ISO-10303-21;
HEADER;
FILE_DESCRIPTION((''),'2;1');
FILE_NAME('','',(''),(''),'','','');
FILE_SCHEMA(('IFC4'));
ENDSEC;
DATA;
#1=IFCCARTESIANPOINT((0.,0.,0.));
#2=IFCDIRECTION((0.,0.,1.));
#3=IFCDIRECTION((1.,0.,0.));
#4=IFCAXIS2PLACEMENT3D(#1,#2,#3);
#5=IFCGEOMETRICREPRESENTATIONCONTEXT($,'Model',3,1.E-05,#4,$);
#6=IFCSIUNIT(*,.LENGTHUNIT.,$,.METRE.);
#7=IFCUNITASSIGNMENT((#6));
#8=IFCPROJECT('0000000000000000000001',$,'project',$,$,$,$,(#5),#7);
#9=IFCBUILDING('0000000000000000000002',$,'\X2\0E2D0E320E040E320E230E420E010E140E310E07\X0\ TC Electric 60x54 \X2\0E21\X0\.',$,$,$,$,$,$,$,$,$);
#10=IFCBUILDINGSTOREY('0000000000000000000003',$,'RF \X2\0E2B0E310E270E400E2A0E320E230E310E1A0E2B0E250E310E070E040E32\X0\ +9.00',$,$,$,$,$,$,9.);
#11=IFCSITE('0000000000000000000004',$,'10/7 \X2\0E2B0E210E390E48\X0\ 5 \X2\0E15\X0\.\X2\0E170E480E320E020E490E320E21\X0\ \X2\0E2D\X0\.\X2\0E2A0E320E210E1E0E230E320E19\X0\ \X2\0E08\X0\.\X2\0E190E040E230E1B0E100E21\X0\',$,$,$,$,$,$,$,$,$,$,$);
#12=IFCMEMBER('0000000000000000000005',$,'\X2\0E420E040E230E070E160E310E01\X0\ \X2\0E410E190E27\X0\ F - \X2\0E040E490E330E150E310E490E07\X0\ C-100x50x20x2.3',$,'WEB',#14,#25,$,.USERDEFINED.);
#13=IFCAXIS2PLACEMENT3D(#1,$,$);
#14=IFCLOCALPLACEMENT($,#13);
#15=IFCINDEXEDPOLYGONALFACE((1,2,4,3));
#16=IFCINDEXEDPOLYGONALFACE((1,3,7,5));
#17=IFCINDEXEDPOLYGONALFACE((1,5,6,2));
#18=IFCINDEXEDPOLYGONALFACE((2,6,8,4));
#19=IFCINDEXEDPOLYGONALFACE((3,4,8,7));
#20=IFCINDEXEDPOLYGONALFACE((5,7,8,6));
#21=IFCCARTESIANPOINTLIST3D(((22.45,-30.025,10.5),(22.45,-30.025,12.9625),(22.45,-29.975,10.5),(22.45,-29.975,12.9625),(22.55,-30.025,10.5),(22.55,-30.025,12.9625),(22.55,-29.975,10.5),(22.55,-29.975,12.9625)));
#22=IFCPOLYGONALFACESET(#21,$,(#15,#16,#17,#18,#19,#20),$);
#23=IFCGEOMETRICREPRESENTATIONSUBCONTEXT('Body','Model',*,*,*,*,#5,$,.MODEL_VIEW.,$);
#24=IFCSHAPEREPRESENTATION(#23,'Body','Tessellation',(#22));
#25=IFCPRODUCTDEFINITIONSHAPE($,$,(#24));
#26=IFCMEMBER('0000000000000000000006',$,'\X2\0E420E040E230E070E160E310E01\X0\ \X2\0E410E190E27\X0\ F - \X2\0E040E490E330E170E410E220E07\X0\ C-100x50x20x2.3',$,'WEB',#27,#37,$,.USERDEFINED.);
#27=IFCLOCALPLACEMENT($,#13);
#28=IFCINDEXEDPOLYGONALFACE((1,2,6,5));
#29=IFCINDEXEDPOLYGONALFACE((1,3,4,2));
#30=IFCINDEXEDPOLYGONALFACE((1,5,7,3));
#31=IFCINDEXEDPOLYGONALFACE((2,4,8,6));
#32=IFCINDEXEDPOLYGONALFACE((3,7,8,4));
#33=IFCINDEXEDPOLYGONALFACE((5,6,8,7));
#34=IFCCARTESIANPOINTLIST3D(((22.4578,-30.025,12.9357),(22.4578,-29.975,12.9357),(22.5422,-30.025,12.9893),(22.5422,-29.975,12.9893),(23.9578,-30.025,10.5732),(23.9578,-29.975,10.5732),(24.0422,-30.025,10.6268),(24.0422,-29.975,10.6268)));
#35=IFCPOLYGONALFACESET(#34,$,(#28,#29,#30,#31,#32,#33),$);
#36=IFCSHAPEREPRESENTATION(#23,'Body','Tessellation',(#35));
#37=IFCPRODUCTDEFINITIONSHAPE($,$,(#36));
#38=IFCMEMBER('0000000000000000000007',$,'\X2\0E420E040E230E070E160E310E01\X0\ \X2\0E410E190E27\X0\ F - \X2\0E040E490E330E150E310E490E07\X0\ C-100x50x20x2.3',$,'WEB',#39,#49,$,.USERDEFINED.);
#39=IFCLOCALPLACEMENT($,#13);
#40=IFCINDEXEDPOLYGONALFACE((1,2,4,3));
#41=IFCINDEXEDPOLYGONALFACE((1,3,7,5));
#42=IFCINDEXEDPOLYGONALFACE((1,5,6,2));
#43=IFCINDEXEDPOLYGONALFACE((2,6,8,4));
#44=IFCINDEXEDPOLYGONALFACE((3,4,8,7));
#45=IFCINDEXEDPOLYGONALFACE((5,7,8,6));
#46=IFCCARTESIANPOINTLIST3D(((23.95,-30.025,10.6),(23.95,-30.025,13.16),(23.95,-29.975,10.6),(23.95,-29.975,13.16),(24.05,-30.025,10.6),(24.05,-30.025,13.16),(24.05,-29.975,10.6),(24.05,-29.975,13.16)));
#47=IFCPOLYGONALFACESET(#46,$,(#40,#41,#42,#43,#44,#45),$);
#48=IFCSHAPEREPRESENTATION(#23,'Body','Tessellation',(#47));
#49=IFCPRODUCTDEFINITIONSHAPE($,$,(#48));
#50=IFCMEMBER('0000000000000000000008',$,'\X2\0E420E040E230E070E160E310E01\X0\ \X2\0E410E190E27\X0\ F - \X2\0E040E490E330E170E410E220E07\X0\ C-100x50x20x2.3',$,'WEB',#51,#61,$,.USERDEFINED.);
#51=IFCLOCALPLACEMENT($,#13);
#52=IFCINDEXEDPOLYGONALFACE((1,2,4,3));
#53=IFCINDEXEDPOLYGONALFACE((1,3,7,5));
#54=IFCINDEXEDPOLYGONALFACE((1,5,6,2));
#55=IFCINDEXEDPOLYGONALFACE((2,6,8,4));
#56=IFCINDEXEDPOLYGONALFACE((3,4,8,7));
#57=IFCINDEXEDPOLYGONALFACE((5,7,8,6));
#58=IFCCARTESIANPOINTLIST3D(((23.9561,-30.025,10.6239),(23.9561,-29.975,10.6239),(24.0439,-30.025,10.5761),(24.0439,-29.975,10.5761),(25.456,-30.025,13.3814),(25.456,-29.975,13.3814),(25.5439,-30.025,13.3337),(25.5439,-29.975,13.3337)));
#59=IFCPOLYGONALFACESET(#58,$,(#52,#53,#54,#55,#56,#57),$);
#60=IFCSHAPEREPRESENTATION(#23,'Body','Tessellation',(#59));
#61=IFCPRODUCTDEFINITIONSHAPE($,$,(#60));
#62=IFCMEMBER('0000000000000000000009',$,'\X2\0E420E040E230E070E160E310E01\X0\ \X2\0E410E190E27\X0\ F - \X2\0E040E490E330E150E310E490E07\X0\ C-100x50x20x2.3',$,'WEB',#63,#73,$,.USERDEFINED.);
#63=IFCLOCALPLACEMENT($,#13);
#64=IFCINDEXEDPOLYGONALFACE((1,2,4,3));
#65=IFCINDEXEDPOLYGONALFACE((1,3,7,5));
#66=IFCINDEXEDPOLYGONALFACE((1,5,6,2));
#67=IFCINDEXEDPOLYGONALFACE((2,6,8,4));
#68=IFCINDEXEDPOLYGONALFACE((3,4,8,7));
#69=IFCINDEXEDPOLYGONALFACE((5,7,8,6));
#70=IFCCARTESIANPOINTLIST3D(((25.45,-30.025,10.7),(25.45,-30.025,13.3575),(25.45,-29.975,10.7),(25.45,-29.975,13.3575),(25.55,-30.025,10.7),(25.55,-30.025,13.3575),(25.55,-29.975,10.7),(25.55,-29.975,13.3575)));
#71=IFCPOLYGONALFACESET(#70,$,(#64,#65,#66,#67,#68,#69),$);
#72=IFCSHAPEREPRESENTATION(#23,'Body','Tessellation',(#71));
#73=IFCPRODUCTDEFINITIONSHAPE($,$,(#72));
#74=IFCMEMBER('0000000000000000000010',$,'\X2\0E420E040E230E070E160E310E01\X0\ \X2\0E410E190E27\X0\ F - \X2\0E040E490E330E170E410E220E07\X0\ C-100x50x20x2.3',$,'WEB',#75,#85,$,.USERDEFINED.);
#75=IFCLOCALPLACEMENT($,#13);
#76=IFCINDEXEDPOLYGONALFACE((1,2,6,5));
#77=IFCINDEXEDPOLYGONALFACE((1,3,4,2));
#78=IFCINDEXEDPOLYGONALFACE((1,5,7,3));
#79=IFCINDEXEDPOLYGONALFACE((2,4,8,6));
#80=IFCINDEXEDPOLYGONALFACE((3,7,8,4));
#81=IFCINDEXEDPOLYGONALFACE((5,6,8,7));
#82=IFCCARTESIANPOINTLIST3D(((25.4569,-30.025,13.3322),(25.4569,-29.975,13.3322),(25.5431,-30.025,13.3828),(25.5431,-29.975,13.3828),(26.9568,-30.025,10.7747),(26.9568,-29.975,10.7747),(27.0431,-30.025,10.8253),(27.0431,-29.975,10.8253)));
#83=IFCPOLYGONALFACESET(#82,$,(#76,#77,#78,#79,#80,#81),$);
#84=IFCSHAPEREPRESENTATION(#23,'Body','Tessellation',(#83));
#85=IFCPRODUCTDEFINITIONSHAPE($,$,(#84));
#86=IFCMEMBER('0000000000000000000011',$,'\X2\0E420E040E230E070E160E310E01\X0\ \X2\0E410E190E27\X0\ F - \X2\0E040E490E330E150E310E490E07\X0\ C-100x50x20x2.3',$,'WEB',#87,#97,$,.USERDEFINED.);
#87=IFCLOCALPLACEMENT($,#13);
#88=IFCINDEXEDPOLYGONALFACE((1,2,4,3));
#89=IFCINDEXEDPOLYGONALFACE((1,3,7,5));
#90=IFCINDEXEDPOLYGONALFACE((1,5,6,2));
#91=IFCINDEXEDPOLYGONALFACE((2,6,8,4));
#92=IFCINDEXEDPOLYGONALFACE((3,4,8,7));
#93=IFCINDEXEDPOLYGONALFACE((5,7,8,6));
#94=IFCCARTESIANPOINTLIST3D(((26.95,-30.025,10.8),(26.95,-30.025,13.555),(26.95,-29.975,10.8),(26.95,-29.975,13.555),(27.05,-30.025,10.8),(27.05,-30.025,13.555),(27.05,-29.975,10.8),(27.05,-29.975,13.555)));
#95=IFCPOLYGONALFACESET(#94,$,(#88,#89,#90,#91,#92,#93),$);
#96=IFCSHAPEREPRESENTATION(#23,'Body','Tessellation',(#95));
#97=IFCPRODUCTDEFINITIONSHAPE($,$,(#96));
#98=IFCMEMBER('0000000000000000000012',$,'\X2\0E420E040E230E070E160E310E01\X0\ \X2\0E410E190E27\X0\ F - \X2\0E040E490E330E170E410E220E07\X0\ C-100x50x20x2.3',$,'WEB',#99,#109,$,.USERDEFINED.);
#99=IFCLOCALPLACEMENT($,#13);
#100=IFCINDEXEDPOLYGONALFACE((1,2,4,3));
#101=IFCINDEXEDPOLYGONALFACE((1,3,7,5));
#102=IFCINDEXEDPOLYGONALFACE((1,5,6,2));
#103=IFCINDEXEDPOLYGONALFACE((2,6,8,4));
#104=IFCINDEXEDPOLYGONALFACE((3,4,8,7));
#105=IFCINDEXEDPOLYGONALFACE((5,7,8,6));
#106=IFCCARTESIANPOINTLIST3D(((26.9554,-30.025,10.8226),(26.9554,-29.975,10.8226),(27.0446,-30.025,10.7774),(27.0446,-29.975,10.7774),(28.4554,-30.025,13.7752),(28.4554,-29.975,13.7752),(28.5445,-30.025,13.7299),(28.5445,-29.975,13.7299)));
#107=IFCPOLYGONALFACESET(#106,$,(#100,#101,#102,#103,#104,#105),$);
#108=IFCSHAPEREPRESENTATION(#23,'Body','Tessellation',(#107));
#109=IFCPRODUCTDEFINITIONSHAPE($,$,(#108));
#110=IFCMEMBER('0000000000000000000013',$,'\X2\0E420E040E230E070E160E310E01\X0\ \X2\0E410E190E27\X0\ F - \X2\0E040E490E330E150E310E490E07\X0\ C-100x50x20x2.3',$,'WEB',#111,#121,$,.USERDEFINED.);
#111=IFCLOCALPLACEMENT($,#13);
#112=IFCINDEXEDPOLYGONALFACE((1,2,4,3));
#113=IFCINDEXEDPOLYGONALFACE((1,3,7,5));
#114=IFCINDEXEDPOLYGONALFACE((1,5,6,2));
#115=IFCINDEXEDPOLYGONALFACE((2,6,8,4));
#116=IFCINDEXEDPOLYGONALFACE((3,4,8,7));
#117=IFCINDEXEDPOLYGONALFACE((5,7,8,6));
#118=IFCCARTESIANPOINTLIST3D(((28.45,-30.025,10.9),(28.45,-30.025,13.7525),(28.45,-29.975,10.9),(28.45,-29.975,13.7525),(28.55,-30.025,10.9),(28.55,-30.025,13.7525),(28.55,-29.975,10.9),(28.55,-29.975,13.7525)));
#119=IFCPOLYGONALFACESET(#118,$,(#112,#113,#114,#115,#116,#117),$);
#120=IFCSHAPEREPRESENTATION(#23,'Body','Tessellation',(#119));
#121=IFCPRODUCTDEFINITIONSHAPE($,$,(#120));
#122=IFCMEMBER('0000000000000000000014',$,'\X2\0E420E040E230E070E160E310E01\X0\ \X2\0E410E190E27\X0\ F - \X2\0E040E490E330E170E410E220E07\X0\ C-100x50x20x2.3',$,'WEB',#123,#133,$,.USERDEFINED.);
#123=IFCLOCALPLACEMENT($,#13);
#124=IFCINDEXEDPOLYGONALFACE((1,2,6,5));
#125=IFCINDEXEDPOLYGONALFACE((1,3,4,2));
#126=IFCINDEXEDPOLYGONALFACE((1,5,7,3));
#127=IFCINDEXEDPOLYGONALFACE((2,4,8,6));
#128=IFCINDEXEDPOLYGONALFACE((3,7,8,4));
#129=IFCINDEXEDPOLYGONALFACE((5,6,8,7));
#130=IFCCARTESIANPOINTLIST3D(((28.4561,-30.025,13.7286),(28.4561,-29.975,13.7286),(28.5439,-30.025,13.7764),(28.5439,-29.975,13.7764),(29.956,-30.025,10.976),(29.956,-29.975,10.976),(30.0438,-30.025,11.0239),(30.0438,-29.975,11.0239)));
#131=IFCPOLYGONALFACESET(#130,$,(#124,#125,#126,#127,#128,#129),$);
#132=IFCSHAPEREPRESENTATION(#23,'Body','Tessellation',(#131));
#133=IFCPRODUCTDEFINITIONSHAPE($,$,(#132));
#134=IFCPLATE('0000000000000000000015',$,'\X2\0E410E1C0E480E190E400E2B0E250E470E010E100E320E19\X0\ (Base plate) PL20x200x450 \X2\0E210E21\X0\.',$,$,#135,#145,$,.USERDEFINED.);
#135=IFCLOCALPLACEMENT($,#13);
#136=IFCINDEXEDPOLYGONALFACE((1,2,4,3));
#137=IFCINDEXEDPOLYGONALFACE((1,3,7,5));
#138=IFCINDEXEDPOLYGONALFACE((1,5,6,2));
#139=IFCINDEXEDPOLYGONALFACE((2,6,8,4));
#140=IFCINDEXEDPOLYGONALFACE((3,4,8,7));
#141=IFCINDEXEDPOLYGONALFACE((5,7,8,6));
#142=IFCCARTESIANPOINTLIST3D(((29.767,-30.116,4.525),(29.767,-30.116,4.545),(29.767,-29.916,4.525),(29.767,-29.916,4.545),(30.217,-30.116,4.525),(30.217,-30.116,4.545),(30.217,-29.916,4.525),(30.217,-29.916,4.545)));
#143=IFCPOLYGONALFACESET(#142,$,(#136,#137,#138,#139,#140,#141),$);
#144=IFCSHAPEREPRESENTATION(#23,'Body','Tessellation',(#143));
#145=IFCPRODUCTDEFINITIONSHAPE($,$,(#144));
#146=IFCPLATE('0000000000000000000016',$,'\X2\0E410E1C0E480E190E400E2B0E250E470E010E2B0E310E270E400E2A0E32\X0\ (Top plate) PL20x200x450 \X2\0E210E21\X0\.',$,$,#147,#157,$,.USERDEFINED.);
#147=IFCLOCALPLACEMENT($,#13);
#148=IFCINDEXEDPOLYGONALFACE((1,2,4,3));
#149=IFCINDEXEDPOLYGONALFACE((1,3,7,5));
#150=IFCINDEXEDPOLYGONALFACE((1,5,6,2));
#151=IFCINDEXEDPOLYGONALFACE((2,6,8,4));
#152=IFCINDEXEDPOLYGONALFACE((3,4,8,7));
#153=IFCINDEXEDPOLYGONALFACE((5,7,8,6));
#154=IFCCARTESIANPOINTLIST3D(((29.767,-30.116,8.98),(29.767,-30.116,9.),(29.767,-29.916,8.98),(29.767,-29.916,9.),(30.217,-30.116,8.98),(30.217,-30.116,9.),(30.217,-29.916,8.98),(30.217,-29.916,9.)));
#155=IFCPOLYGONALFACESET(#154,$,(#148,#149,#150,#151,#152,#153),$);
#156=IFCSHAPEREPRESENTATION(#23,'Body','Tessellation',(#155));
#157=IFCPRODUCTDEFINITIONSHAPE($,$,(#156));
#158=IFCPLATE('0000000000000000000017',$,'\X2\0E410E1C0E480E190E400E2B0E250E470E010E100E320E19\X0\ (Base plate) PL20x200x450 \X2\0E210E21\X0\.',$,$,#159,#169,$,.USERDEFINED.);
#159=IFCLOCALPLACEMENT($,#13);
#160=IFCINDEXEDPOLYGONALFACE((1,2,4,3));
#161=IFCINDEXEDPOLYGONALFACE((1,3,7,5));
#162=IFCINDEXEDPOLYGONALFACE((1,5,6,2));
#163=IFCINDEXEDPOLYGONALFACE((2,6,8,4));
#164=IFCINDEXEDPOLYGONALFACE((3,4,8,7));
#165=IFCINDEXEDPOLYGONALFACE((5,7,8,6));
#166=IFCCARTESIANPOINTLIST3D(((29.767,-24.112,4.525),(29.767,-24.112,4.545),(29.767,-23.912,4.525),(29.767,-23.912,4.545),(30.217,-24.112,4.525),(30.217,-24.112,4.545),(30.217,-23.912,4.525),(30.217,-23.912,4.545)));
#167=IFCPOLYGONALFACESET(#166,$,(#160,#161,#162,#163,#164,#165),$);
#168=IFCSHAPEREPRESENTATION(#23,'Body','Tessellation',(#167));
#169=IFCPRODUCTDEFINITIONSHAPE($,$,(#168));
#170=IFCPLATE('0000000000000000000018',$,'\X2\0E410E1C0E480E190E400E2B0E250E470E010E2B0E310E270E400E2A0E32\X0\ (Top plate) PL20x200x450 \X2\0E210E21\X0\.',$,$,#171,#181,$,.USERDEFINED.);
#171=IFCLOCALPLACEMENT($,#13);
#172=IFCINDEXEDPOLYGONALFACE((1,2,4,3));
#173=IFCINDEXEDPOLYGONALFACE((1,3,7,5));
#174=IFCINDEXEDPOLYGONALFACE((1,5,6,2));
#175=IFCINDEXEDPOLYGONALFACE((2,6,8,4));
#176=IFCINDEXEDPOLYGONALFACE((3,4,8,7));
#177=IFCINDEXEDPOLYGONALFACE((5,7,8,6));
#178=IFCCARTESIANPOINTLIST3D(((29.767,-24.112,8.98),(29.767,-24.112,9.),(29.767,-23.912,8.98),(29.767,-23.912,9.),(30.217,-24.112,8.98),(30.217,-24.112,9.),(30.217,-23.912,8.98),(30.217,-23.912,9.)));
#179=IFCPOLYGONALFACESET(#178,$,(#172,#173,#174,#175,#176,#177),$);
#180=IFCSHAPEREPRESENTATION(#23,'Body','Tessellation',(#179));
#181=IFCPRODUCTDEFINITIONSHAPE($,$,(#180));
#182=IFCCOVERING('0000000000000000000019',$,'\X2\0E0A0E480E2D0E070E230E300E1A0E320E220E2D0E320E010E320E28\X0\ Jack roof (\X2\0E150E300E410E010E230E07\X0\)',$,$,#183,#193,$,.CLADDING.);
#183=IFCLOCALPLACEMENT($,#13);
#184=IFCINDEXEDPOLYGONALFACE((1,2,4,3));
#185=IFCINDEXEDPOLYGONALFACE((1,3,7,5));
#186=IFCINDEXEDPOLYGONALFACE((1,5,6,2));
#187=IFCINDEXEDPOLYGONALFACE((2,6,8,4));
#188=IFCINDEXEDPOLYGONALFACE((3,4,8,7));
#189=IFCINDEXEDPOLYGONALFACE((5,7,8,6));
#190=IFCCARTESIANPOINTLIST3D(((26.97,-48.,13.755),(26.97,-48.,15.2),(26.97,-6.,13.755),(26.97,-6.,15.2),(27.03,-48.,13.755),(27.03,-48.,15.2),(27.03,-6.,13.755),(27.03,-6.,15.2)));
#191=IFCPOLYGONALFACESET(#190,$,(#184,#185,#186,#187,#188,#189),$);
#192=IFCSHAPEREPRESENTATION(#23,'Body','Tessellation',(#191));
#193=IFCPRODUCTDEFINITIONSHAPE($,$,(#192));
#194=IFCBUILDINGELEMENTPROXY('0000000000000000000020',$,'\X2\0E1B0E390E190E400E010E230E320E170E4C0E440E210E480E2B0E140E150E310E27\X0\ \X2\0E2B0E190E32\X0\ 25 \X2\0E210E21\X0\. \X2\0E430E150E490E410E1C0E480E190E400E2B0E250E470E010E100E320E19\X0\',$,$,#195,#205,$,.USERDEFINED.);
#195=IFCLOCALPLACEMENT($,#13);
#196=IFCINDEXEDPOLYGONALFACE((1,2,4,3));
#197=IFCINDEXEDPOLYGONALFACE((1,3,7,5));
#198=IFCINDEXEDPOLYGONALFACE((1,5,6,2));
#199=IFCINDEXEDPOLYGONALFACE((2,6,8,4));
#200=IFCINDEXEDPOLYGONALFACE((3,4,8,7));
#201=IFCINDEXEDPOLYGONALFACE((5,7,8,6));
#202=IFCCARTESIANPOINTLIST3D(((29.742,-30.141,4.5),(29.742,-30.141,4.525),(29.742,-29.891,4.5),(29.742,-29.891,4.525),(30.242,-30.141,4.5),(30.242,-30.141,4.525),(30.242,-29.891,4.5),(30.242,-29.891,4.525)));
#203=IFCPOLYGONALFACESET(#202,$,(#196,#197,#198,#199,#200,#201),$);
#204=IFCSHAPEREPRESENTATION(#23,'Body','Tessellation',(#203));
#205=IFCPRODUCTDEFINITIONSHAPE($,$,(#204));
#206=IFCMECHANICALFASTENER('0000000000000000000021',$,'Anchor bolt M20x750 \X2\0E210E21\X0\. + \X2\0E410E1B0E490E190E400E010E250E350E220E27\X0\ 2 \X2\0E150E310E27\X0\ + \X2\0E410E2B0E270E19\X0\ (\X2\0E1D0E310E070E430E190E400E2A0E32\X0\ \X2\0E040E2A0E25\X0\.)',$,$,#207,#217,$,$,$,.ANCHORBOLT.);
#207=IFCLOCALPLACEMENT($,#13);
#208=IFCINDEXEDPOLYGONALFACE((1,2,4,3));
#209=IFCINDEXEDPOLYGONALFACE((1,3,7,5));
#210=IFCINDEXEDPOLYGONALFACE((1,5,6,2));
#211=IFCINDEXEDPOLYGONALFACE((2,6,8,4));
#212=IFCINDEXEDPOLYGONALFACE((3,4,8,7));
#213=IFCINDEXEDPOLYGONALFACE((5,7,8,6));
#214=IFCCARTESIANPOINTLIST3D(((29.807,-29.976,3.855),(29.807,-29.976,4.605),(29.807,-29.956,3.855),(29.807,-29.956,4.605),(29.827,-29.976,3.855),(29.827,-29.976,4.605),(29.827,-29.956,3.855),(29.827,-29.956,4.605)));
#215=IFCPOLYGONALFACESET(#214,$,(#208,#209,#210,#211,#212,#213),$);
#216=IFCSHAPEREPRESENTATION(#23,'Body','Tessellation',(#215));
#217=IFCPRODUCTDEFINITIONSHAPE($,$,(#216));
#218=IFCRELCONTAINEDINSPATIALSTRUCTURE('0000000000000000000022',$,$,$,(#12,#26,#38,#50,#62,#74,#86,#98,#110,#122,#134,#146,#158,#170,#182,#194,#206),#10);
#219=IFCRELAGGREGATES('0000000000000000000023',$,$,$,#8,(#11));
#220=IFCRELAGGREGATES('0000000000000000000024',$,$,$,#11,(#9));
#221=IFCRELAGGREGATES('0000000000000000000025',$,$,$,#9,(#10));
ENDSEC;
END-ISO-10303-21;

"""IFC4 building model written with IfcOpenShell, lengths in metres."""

from ifc_helpers import new_model, si_unit, frame, origin, origin_with_axes, origin_2d, place, context, subcontext, project, spatial, rectangle, extrude, element, save


model = new_model("IFC4")

# Units and contexts
model_context = context("Model", 3, precision=1e-05, world=origin_with_axes())
body_context = subcontext(model_context, "Body", "Model", "MODEL_VIEW")
ifc_project = project(units=[si_unit("LENGTHUNIT", "METRE")], contexts=[model_context])

# Site, building, storey
site = spatial("IfcSite", under=ifc_project, Name="10/7 หมู่ 5 ต.ท่าข้าม อ.สามพราน จ.นครปฐม")
building = spatial("IfcBuilding", under=site, Name="อาคารโกดัง TC Electric 60x54 ม.")
storey = spatial("IfcBuildingStorey", under=building, Name="RF หัวเสารับหลังคา +9.00", Elevation=9.0)

# Members
member_1_placement = place(None, frame((22.5, -30.0, 10.5), z_axis=(0.0, 0.0, 1.0), x_axis=(0.0, 1.0, 0.0)))
element("IfcMember", 1, at=member_1_placement, inside=storey, Name="โครงถัก แนว F - ค้ำตั้ง C-100x50x20x2.3", ObjectType="WEB", PredefinedType="USERDEFINED", context=body_context, shape_type="SweptSolid", body=[
    extrude(rectangle(XDim=0.05, YDim=0.1, at=origin_2d()), origin(), (0.0, 0.0, 1.0), 2.4625),
])
member_2_placement = place(None, frame((22.5, -30.0, 12.9625), z_axis=(0.536, 0.0, -0.8442), x_axis=(0.0, -1.0, 0.0)))
element("IfcMember", 2, at=member_2_placement, inside=storey, Name="โครงถัก แนว F - ค้ำทแยง C-100x50x20x2.3", ObjectType="WEB", PredefinedType="USERDEFINED", context=body_context, shape_type="SweptSolid", body=[
    extrude(rectangle(XDim=0.05, YDim=0.1, at=origin_2d()), origin(), (0.0, 0.0, 1.0), 2.7985),
])
member_3_placement = place(None, frame((24.0, -30.0, 10.6), z_axis=(0.0, 0.0, 1.0), x_axis=(0.0, 1.0, 0.0)))
element("IfcMember", 3, at=member_3_placement, inside=storey, Name="โครงถัก แนว F - ค้ำตั้ง C-100x50x20x2.3", ObjectType="WEB", PredefinedType="USERDEFINED", context=body_context, shape_type="SweptSolid", body=[
    extrude(rectangle(XDim=0.05, YDim=0.1, at=origin_2d()), origin(), (0.0, 0.0, 1.0), 2.56),
])
member_4_placement = place(None, frame((24.0, -30.0, 10.6), z_axis=(0.4778, 0.0, 0.8784), x_axis=(0.0, -1.0, 0.0)))
element("IfcMember", 4, at=member_4_placement, inside=storey, Name="โครงถัก แนว F - ค้ำทแยง C-100x50x20x2.3", ObjectType="WEB", PredefinedType="USERDEFINED", context=body_context, shape_type="SweptSolid", body=[
    extrude(rectangle(XDim=0.05, YDim=0.1, at=origin_2d()), origin(), (0.0, 0.0, 1.0), 3.1391),
])
member_5_placement = place(None, frame((25.5, -30.0, 10.7), z_axis=(0.0, 0.0, 1.0), x_axis=(0.0, 1.0, 0.0)))
element("IfcMember", 5, at=member_5_placement, inside=storey, Name="โครงถัก แนว F - ค้ำตั้ง C-100x50x20x2.3", ObjectType="WEB", PredefinedType="USERDEFINED", context=body_context, shape_type="SweptSolid", body=[
    extrude(rectangle(XDim=0.05, YDim=0.1, at=origin_2d()), origin(), (0.0, 0.0, 1.0), 2.6575),
])
member_6_placement = place(None, frame((25.5, -30.0, 13.3575), z_axis=(0.5059, 0.0, -0.8626), x_axis=(0.0, -1.0, 0.0)))
element("IfcMember", 6, at=member_6_placement, inside=storey, Name="โครงถัก แนว F - ค้ำทแยง C-100x50x20x2.3", ObjectType="WEB", PredefinedType="USERDEFINED", context=body_context, shape_type="SweptSolid", body=[
    extrude(rectangle(XDim=0.05, YDim=0.1, at=origin_2d()), origin(), (0.0, 0.0, 1.0), 2.9649),
])
member_7_placement = place(None, frame((27.0, -30.0, 10.8), z_axis=(0.0, 0.0, 1.0), x_axis=(0.0, 1.0, 0.0)))
element("IfcMember", 7, at=member_7_placement, inside=storey, Name="โครงถัก แนว F - ค้ำตั้ง C-100x50x20x2.3", ObjectType="WEB", PredefinedType="USERDEFINED", context=body_context, shape_type="SweptSolid", body=[
    extrude(rectangle(XDim=0.05, YDim=0.1, at=origin_2d()), origin(), (0.0, 0.0, 1.0), 2.755),
])
member_8_placement = place(None, frame((27.0, -30.0, 10.8), z_axis=(0.4529, 0.0, 0.8915), x_axis=(0.0, -1.0, 0.0)))
element("IfcMember", 8, at=member_8_placement, inside=storey, Name="โครงถัก แนว F - ค้ำทแยง C-100x50x20x2.3", ObjectType="WEB", PredefinedType="USERDEFINED", context=body_context, shape_type="SweptSolid", body=[
    extrude(rectangle(XDim=0.05, YDim=0.1, at=origin_2d()), origin(), (0.0, 0.0, 1.0), 3.3117),
])
member_9_placement = place(None, frame((28.5, -30.0, 10.9), z_axis=(0.0, 0.0, 1.0), x_axis=(0.0, 1.0, 0.0)))
element("IfcMember", 9, at=member_9_placement, inside=storey, Name="โครงถัก แนว F - ค้ำตั้ง C-100x50x20x2.3", ObjectType="WEB", PredefinedType="USERDEFINED", context=body_context, shape_type="SweptSolid", body=[
    extrude(rectangle(XDim=0.05, YDim=0.1, at=origin_2d()), origin(), (0.0, 0.0, 1.0), 2.8525),
])
member_10_placement = place(None, frame((28.5, -30.0, 13.7525), z_axis=(0.4785, 0.0, -0.8781), x_axis=(0.0, -1.0, 0.0)))
element("IfcMember", 10, at=member_10_placement, inside=storey, Name="โครงถัก แนว F - ค้ำทแยง C-100x50x20x2.3", ObjectType="WEB", PredefinedType="USERDEFINED", context=body_context, shape_type="SweptSolid", body=[
    extrude(rectangle(XDim=0.05, YDim=0.1, at=origin_2d()), origin(), (0.0, 0.0, 1.0), 3.1347),
])

# Plates
for number, where, z_axis, x_axis, name in (
    (11, (29.992, -30.016, 4.525), (0.0, 0.0, 1.0), (1.0, 0.0, 0.0), "แผ่นเหล็กฐาน (Base plate) PL20x200x450 มม."),
    (12, (29.992, -30.016, 8.98), (0.0, 0.0, 1.0), (1.0, 0.0, 0.0), "แผ่นเหล็กหัวเสา (Top plate) PL20x200x450 มม."),
    (13, (29.992, -24.012, 4.525), (0.0, 0.0, 1.0), (1.0, 0.0, 0.0), "แผ่นเหล็กฐาน (Base plate) PL20x200x450 มม."),
    (14, (29.992, -24.012, 8.98), (0.0, 0.0, 1.0), (1.0, 0.0, 0.0), "แผ่นเหล็กหัวเสา (Top plate) PL20x200x450 มม."),
):
    element("IfcPlate", number, at=place(None, frame(where, z_axis=z_axis, x_axis=x_axis)), inside=storey, Name=name, PredefinedType="USERDEFINED", context=body_context, shape_type="SweptSolid", body=[
        extrude(rectangle(XDim=0.45, YDim=0.2, at=origin_2d()), origin(), (0.0, 0.0, 1.0), 0.02),
    ])

# Covering
covering_placement = place(None, frame((27.0, -27.0, 13.755), z_axis=(0.0, 0.0, 1.0), x_axis=(1.0, 0.0, 0.0)))
element("IfcCovering", 15, at=covering_placement, inside=storey, Name="ช่องระบายอากาศ Jack roof (ตะแกรง)", PredefinedType="CLADDING", context=body_context, shape_type="SweptSolid", body=[
    extrude(rectangle(XDim=0.06, YDim=42.0, at=origin_2d()), origin(), (0.0, 0.0, 1.0), 1.445),
])

# Building element proxy
proxy_1_placement = place(None, frame((29.992, -30.016, 4.5), z_axis=(0.0, 0.0, 1.0), x_axis=(1.0, 0.0, 0.0)))
element("IfcBuildingElementProxy", 16, at=proxy_1_placement, inside=storey, Name="ปูนเกราท์ไม่หดตัว หนา 25 มม. ใต้แผ่นเหล็กฐาน", PredefinedType="USERDEFINED", context=body_context, shape_type="SweptSolid", body=[
    extrude(rectangle(XDim=0.5, YDim=0.25, at=origin_2d()), origin(), (0.0, 0.0, 1.0), 0.025),
])

# Mechanical fastener
for number, where, z_axis, x_axis, name in (
    (17, (29.817, -29.966, 3.855), (0.0, 0.0, 1.0), (1.0, 0.0, 0.0), "Anchor bolt M20x750 มม. + แป้นเกลียว 2 ตัว + แหวน (ฝังในเสา คสล.)"),
):
    element("IfcMechanicalFastener", number, at=place(None, frame(where, z_axis=z_axis, x_axis=x_axis)), inside=storey, Name=name, PredefinedType="ANCHORBOLT", context=body_context, shape_type="SweptSolid", body=[
        extrude(rectangle(XDim=0.02, YDim=0.02, at=origin_2d()), origin(), (0.0, 0.0, 1.0), 0.75),
    ])

save(model, "model.ifc")
